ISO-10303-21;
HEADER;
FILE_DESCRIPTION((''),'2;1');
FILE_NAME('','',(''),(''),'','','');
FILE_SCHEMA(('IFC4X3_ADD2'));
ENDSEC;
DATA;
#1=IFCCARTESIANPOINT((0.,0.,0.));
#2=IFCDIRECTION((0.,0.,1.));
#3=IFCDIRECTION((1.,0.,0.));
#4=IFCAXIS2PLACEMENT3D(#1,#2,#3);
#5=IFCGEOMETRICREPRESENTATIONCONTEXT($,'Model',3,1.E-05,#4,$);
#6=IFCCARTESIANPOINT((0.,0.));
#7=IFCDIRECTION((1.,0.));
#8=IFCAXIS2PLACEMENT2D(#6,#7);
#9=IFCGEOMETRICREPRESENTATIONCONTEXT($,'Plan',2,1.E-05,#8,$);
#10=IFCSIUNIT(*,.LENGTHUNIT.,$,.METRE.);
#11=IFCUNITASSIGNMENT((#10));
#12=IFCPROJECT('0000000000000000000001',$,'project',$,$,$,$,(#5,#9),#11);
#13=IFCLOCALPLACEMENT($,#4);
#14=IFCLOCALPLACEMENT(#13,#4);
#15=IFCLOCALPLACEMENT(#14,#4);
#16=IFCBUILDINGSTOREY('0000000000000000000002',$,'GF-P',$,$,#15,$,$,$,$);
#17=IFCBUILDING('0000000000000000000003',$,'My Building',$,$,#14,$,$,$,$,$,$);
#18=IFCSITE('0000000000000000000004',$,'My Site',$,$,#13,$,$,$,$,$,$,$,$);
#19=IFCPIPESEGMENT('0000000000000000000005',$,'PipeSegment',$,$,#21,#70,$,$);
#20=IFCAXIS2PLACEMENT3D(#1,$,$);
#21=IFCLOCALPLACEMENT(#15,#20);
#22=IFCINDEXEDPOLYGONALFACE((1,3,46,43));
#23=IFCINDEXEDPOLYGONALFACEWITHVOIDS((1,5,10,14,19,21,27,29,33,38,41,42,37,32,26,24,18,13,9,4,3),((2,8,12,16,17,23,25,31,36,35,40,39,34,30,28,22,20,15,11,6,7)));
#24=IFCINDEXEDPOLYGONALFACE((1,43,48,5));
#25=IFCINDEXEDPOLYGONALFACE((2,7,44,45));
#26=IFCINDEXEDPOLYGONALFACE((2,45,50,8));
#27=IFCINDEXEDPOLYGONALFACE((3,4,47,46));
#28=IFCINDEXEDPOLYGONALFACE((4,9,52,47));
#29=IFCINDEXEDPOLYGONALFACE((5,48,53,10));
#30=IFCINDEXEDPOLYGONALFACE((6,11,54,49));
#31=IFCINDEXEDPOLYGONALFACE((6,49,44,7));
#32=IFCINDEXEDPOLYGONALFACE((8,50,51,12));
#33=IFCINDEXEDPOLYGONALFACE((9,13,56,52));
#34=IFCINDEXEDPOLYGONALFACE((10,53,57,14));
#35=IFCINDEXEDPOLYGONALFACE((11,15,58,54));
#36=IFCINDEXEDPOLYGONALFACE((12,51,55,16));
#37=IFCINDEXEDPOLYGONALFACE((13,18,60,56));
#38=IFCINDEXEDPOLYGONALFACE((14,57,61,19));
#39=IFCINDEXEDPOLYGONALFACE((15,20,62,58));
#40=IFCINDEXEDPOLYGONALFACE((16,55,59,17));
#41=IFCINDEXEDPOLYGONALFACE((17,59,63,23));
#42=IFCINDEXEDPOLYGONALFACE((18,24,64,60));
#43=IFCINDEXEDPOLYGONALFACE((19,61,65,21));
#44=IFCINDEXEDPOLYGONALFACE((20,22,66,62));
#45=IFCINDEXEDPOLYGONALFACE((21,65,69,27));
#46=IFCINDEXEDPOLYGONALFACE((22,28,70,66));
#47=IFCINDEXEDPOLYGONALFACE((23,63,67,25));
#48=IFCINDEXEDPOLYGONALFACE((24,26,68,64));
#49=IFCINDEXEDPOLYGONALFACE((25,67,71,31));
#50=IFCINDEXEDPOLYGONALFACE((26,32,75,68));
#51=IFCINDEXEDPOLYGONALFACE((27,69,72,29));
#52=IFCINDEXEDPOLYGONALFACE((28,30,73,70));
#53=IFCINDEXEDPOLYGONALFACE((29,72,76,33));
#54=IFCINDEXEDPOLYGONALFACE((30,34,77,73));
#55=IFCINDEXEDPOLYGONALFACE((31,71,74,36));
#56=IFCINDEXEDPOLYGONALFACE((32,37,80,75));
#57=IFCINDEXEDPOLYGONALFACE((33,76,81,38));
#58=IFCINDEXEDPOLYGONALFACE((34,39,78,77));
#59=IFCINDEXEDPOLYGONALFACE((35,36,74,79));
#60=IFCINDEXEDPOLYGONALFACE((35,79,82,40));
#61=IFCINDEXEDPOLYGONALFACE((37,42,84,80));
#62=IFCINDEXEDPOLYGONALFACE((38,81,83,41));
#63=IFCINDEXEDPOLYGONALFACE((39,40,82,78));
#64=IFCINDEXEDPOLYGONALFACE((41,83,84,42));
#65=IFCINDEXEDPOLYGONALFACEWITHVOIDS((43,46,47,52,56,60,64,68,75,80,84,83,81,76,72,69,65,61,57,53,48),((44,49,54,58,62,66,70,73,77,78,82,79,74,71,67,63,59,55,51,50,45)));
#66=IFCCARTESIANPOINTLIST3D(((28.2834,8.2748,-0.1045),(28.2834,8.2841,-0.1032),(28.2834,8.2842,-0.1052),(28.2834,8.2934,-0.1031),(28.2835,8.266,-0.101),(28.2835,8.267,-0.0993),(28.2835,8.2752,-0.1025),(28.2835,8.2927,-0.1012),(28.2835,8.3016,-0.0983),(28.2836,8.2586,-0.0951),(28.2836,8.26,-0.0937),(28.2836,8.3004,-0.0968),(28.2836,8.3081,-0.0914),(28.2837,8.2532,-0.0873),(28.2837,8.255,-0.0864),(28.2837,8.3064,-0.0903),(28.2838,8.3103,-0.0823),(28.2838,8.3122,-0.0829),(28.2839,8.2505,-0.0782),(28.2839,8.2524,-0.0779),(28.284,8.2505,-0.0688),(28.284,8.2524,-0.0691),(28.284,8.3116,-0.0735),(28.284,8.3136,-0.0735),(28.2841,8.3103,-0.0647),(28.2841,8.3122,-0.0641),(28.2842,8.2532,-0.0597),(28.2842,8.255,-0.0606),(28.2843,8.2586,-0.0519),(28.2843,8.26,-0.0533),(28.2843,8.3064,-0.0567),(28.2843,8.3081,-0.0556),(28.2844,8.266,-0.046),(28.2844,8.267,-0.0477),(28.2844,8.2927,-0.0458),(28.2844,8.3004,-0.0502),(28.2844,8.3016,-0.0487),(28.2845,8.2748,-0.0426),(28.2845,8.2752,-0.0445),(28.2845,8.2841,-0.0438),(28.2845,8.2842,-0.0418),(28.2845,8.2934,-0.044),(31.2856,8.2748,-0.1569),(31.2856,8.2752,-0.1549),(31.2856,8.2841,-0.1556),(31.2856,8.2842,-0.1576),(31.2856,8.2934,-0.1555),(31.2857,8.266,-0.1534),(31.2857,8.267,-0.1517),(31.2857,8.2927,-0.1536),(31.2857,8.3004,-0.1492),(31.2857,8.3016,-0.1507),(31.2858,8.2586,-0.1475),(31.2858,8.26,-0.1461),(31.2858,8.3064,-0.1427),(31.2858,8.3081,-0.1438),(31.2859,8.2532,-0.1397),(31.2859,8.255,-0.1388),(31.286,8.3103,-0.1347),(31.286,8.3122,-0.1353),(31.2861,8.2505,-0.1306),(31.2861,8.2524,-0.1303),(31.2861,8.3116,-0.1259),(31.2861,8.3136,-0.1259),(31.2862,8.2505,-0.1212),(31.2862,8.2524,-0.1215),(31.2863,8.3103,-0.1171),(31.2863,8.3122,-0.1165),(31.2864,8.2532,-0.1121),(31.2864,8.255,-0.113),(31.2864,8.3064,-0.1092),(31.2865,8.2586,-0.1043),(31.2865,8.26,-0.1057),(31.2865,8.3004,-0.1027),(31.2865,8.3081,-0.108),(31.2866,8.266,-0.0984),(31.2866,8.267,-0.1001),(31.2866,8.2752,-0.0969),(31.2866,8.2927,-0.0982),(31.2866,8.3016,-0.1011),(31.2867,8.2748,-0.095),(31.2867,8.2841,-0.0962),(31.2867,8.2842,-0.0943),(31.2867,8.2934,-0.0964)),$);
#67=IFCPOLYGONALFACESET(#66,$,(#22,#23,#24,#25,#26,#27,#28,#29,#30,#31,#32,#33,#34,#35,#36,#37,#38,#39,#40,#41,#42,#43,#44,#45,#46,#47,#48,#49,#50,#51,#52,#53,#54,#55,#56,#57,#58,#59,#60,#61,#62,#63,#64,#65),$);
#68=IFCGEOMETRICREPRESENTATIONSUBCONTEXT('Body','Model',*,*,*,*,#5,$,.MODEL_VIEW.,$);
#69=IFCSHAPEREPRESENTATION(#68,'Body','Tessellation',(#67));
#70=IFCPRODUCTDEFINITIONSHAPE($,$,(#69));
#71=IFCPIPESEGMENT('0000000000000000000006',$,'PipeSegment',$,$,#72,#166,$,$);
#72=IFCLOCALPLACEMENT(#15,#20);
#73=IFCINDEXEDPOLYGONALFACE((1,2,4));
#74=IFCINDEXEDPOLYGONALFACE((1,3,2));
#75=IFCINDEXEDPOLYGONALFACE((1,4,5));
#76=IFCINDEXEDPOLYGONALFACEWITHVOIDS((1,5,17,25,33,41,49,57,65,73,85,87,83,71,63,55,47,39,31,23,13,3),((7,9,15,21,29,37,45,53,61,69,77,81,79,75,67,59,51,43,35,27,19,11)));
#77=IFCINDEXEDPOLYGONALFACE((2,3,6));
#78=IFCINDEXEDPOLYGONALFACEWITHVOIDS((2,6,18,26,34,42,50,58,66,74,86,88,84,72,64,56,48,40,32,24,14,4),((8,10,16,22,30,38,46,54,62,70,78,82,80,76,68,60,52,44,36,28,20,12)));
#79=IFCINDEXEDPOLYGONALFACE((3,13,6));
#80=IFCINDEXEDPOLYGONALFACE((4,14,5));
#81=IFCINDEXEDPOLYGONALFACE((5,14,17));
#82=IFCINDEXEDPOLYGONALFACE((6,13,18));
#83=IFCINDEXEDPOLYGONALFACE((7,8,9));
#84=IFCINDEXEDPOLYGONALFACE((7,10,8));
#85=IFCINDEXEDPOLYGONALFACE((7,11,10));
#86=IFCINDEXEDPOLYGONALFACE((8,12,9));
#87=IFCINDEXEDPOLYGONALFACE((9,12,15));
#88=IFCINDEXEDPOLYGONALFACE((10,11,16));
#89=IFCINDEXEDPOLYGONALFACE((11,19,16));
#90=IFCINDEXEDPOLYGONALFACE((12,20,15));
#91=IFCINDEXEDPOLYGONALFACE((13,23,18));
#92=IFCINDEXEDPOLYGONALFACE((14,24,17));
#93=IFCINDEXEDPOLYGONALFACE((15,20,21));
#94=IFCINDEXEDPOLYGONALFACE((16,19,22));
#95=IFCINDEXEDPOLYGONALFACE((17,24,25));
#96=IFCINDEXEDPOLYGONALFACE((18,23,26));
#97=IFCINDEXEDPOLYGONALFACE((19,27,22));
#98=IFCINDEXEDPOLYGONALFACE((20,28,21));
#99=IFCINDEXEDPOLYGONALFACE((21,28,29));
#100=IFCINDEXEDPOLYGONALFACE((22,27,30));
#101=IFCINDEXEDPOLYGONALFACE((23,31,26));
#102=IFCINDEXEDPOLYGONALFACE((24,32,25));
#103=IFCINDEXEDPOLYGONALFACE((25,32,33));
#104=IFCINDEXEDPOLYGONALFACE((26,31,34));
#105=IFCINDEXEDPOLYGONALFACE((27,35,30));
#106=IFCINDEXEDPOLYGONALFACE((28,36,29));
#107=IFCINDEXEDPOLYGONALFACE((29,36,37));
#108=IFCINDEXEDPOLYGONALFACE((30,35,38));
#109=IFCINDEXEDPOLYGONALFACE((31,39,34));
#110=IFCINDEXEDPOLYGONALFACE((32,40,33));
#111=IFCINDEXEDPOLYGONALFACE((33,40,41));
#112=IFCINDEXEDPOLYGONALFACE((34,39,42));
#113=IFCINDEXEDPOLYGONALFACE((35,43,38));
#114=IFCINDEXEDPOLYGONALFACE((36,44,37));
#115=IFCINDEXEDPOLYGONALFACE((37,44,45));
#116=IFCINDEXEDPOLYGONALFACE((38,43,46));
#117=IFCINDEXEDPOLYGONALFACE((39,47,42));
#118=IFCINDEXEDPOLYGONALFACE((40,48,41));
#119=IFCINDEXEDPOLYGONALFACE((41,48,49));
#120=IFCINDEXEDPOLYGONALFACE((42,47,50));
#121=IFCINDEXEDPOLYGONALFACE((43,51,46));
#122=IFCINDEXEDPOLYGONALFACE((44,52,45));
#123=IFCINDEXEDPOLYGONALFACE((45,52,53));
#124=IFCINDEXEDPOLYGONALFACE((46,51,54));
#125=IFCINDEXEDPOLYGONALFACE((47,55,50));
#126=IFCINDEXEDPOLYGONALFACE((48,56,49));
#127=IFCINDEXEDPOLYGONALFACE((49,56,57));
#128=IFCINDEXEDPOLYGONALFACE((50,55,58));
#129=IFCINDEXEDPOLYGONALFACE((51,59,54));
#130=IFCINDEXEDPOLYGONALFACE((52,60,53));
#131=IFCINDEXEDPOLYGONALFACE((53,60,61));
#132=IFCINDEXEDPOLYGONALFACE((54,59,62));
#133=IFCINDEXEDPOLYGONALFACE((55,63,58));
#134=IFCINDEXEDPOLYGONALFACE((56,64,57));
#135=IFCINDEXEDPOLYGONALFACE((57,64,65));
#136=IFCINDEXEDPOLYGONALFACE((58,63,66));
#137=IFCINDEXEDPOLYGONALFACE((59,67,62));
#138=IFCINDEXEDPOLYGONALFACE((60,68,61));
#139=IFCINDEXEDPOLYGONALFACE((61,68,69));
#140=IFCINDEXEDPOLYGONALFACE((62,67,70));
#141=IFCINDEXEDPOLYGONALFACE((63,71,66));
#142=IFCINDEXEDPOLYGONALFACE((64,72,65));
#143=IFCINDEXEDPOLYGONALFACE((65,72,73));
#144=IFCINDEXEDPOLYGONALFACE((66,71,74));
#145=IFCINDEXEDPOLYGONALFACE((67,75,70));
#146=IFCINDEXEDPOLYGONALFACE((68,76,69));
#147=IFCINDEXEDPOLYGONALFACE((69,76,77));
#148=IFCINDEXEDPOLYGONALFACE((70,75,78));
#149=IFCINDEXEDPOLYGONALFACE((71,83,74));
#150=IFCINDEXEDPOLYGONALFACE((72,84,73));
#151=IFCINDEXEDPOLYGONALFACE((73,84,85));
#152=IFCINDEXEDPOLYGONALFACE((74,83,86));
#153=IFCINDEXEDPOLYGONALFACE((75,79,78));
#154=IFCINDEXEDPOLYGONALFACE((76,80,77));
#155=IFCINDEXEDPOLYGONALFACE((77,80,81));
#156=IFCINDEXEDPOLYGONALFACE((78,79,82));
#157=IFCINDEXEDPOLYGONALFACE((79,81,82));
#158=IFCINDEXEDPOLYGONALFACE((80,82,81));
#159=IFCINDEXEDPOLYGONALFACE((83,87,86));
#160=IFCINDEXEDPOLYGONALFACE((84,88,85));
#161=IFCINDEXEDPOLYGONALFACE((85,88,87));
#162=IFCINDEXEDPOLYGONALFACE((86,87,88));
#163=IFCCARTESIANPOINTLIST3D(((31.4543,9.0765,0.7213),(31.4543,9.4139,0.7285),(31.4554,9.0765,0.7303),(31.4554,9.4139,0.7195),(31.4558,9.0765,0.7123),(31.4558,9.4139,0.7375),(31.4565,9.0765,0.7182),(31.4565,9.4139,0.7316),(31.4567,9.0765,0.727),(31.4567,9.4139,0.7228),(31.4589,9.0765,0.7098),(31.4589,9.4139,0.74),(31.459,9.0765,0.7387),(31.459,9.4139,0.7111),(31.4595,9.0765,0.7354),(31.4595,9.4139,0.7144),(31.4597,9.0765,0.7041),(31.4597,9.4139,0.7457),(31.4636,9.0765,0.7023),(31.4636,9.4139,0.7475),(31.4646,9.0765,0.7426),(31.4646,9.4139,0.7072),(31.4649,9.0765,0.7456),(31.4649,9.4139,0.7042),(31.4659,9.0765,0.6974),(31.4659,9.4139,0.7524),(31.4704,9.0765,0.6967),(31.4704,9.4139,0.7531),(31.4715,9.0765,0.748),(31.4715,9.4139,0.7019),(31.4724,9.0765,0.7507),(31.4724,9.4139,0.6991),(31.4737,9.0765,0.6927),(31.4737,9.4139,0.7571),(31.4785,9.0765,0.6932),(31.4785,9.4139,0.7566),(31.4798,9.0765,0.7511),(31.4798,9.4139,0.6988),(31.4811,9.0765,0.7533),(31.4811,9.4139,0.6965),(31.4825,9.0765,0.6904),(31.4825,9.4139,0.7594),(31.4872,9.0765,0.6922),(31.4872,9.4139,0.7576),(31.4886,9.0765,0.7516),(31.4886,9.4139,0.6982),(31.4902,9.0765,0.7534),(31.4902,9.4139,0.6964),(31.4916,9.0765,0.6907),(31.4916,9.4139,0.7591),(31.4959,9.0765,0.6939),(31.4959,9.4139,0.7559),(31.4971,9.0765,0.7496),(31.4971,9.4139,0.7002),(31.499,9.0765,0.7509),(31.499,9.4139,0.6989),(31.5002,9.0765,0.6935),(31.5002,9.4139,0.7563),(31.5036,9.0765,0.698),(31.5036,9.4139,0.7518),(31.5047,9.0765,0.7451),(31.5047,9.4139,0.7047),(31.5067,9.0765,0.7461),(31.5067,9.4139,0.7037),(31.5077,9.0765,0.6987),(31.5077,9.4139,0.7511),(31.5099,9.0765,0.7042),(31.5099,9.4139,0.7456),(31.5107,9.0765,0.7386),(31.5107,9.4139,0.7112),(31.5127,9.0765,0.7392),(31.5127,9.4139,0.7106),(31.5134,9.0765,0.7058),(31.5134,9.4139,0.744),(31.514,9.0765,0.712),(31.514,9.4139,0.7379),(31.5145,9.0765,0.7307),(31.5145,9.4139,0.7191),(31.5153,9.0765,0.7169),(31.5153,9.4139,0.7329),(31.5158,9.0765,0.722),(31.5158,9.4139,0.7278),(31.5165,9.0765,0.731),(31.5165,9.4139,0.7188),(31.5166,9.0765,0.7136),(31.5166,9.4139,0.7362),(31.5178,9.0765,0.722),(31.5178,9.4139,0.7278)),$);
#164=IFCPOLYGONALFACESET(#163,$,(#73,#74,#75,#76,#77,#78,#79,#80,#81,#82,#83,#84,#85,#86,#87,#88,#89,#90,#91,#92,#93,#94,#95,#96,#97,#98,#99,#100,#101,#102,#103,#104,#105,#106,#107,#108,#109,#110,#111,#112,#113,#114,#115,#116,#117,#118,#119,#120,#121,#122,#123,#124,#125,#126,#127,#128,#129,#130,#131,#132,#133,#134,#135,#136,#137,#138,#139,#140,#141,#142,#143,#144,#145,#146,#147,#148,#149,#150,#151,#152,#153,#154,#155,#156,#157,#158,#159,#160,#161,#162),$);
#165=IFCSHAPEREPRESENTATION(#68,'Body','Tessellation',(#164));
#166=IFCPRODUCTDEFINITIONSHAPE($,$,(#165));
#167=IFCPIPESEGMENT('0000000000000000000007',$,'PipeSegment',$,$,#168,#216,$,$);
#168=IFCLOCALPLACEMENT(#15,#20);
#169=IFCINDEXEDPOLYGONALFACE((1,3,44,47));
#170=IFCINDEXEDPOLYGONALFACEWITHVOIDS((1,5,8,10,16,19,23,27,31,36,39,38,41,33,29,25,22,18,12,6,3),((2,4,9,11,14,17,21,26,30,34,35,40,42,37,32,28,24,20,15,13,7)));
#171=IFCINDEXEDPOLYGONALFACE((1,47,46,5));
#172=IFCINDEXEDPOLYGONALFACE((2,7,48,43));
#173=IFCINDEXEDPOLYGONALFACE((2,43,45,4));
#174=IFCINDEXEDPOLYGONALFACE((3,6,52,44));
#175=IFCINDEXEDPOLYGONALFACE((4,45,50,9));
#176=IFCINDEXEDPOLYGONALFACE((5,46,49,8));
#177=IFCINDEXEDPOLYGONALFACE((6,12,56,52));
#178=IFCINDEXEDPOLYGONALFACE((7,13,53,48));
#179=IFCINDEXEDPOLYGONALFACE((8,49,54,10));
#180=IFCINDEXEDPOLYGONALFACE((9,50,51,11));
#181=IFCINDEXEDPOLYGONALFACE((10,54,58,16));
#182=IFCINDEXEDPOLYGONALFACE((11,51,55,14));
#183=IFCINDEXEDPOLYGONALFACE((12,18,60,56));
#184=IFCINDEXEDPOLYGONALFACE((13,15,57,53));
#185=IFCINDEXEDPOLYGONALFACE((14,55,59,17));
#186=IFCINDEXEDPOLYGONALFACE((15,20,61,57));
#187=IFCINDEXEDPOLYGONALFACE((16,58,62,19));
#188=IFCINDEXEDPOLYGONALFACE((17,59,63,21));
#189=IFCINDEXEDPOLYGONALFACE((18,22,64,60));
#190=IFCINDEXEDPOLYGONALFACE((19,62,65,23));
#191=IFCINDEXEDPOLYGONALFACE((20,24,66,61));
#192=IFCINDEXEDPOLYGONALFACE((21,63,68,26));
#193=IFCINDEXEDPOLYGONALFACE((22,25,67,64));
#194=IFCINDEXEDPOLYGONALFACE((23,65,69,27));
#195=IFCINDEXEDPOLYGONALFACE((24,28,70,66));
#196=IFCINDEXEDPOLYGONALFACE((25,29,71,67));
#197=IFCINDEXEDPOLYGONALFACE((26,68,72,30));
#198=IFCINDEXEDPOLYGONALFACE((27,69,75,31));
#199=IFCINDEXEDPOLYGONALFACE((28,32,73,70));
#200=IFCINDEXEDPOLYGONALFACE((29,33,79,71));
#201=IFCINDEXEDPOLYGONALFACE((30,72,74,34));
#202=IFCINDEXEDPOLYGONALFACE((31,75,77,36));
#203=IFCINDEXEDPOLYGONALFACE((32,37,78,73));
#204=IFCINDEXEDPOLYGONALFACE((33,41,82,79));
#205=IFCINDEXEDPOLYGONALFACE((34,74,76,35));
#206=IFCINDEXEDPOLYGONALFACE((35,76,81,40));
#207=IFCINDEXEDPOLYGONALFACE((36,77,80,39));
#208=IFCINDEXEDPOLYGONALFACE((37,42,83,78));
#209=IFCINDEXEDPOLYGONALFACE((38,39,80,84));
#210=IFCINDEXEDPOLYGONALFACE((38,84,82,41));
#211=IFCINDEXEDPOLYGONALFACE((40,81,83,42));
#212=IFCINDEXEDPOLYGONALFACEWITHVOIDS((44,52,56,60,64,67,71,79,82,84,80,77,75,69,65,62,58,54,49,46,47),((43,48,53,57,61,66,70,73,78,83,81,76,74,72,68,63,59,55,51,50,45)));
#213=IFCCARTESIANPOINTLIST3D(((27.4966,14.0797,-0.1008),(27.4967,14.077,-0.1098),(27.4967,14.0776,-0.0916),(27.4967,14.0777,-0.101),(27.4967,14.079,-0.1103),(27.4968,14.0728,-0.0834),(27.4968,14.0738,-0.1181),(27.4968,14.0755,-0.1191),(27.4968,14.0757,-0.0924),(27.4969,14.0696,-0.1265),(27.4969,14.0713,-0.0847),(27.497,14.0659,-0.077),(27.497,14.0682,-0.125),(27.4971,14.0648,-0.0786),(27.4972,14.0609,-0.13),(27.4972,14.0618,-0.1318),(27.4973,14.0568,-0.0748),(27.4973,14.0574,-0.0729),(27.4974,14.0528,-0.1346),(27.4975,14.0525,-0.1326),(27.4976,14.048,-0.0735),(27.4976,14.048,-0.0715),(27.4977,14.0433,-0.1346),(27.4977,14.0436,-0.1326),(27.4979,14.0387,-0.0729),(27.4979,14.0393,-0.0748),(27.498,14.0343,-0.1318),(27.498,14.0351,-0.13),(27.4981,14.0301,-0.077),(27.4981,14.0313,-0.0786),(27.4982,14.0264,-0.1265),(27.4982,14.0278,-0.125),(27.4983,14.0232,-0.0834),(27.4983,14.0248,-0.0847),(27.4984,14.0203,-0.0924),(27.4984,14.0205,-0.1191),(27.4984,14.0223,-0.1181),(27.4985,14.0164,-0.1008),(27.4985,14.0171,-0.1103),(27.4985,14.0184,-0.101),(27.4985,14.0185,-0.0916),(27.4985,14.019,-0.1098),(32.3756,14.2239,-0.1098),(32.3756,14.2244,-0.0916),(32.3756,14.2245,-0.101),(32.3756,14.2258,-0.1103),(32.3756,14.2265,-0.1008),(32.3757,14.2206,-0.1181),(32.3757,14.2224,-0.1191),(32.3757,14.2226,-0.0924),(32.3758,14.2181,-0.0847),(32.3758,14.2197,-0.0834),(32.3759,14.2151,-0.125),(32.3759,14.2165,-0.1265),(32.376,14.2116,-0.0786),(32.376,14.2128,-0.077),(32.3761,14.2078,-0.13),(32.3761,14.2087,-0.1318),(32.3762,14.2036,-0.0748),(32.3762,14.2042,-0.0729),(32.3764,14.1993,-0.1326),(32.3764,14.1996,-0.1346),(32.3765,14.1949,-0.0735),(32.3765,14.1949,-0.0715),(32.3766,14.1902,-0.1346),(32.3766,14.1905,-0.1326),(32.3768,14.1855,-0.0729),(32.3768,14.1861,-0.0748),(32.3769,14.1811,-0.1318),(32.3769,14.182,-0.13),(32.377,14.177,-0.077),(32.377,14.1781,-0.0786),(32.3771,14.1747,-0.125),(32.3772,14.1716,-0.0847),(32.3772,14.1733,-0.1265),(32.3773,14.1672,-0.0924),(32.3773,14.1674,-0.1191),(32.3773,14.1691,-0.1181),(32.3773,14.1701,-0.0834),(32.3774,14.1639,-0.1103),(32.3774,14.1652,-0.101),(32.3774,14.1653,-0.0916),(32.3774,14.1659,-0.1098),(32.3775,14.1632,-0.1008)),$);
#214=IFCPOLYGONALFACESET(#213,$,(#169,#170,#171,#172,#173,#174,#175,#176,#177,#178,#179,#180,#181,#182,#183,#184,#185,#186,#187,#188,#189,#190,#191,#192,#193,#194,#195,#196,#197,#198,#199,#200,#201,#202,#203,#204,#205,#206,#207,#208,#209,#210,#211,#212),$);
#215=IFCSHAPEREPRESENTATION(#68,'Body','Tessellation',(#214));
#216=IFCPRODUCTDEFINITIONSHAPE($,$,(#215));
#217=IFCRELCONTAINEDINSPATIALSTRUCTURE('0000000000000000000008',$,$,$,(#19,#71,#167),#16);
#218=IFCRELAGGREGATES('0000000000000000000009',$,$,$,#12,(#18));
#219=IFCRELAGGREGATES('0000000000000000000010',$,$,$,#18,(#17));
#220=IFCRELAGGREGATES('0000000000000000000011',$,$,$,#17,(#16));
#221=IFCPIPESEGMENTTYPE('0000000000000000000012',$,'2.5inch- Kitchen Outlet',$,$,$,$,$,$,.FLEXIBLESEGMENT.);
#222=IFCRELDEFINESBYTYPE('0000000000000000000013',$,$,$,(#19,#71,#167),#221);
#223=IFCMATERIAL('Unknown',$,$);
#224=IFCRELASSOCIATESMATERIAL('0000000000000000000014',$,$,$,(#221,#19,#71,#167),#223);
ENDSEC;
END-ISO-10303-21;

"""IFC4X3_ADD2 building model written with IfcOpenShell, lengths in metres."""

from ifc_helpers import new_model, si_unit, frame, origin_with_axes, origin_2d_with_axis, place, context, subcontext, project, spatial, hollow_circle, extrude, clip, halfspace, material, material_profile, profile_set, profile_usage, type_object, element, save


model = new_model("IFC4X3_ADD2")

# Units and contexts
model_context = context("Model", 3, precision=1e-05, world=origin_with_axes())
plan_context = context("Plan", 2, precision=1e-05, world=origin_2d_with_axis())
body_context = subcontext(model_context, "Body", "Model", "MODEL_VIEW")
ifc_project = project(units=[si_unit("LENGTHUNIT", "METRE")], contexts=[model_context, plan_context])

# Site, building, storey
site_placement = place(None, origin_with_axes())
site = spatial("IfcSite", under=ifc_project, at=site_placement, Name="My Site")
building_placement = place(site_placement, origin_with_axes())
building = spatial("IfcBuilding", under=site, at=building_placement, Name="My Building")
storey_placement = place(building_placement, origin_with_axes())
storey = spatial("IfcBuildingStorey", under=building, at=storey_placement, Name="GF-P")

# Pipe segments
ifc_material_1 = material(Name="Unknown")
ifc_material_profile_1 = material_profile(ifc_material_1, hollow_circle(Radius=0.0318, WallThickness=0.002))
ifc_profile_set_1 = profile_set([ifc_material_profile_1], Name="kitchenwater")
pipe_segment_type_1 = type_object("IfcPipeSegmentType", Name="2.5inch- Kitchen Outlet", PredefinedType="FLEXIBLESEGMENT", material=ifc_profile_set_1)
ifc_profile_usage_1 = profile_usage(ifc_profile_set_1)
pipe_segment_1_placement = place(storey_placement, frame((28.284, 8.2818, -0.0735), z_axis=(0.999848, 0.0, -0.017452), x_axis=(0.0, 1.0, 0.0)))
element("IfcPipeSegment", 1, at=pipe_segment_1_placement, inside=storey, type_object=pipe_segment_type_1, material=ifc_profile_usage_1, Name="PipeSegment", context=body_context, shape_type="SweptSolid", body=[
    extrude(hollow_circle(Radius=0.0318, WallThickness=0.002), origin_with_axes(), (0.0, 0.0, 1.0), 3.0026),
])
ifc_profile_usage_2 = profile_usage(ifc_profile_set_1)
pipe_segment_2_placement = place(storey_placement, frame((31.486, 9.4773, 0.729), z_axis=(0.0, -0.999848, -0.017452), x_axis=(1.0, 0.0, 0.0)))
element("IfcPipeSegment", 2, at=pipe_segment_2_placement, inside=storey, type_object=pipe_segment_type_1, material=ifc_profile_usage_2, Name="PipeSegment", context=body_context, shape_type="Clipping", body=[
    clip(clip(extrude(hollow_circle(Radius=0.0318, WallThickness=0.002), origin_with_axes(), (0.0, 0.0, 1.0), 0.4642), halfspace(frame((0.0, -0.0946, 0.0651), z_axis=(0.0, -0.017452, -0.999848), x_axis=(-1.0, 0.000005, 0.0)), False)), halfspace(frame((0.0, -0.9386, 0.4172), z_axis=(0.0, 0.017452, 0.999848), x_axis=(1.0, -0.000005, 0.0)), False)),
])
ifc_profile_usage_3 = profile_usage(ifc_profile_set_1)
pipe_segment_3_placement = place(storey_placement, frame((27.4976, 14.048, -0.1032), z_axis=(0.999547, 0.030087, -0.000001), x_axis=(0.000001, 0.0, 1.0)))
element("IfcPipeSegment", 3, at=pipe_segment_3_placement, inside=storey, type_object=pipe_segment_type_1, material=ifc_profile_usage_3, Name="PipeSegment", context=body_context, shape_type="SweptSolid", body=[
    extrude(hollow_circle(Radius=0.0318, WallThickness=0.002), origin_with_axes(), (0.0, 0.0, 1.0), 4.8811),
])

save(model, "model.ifc")
